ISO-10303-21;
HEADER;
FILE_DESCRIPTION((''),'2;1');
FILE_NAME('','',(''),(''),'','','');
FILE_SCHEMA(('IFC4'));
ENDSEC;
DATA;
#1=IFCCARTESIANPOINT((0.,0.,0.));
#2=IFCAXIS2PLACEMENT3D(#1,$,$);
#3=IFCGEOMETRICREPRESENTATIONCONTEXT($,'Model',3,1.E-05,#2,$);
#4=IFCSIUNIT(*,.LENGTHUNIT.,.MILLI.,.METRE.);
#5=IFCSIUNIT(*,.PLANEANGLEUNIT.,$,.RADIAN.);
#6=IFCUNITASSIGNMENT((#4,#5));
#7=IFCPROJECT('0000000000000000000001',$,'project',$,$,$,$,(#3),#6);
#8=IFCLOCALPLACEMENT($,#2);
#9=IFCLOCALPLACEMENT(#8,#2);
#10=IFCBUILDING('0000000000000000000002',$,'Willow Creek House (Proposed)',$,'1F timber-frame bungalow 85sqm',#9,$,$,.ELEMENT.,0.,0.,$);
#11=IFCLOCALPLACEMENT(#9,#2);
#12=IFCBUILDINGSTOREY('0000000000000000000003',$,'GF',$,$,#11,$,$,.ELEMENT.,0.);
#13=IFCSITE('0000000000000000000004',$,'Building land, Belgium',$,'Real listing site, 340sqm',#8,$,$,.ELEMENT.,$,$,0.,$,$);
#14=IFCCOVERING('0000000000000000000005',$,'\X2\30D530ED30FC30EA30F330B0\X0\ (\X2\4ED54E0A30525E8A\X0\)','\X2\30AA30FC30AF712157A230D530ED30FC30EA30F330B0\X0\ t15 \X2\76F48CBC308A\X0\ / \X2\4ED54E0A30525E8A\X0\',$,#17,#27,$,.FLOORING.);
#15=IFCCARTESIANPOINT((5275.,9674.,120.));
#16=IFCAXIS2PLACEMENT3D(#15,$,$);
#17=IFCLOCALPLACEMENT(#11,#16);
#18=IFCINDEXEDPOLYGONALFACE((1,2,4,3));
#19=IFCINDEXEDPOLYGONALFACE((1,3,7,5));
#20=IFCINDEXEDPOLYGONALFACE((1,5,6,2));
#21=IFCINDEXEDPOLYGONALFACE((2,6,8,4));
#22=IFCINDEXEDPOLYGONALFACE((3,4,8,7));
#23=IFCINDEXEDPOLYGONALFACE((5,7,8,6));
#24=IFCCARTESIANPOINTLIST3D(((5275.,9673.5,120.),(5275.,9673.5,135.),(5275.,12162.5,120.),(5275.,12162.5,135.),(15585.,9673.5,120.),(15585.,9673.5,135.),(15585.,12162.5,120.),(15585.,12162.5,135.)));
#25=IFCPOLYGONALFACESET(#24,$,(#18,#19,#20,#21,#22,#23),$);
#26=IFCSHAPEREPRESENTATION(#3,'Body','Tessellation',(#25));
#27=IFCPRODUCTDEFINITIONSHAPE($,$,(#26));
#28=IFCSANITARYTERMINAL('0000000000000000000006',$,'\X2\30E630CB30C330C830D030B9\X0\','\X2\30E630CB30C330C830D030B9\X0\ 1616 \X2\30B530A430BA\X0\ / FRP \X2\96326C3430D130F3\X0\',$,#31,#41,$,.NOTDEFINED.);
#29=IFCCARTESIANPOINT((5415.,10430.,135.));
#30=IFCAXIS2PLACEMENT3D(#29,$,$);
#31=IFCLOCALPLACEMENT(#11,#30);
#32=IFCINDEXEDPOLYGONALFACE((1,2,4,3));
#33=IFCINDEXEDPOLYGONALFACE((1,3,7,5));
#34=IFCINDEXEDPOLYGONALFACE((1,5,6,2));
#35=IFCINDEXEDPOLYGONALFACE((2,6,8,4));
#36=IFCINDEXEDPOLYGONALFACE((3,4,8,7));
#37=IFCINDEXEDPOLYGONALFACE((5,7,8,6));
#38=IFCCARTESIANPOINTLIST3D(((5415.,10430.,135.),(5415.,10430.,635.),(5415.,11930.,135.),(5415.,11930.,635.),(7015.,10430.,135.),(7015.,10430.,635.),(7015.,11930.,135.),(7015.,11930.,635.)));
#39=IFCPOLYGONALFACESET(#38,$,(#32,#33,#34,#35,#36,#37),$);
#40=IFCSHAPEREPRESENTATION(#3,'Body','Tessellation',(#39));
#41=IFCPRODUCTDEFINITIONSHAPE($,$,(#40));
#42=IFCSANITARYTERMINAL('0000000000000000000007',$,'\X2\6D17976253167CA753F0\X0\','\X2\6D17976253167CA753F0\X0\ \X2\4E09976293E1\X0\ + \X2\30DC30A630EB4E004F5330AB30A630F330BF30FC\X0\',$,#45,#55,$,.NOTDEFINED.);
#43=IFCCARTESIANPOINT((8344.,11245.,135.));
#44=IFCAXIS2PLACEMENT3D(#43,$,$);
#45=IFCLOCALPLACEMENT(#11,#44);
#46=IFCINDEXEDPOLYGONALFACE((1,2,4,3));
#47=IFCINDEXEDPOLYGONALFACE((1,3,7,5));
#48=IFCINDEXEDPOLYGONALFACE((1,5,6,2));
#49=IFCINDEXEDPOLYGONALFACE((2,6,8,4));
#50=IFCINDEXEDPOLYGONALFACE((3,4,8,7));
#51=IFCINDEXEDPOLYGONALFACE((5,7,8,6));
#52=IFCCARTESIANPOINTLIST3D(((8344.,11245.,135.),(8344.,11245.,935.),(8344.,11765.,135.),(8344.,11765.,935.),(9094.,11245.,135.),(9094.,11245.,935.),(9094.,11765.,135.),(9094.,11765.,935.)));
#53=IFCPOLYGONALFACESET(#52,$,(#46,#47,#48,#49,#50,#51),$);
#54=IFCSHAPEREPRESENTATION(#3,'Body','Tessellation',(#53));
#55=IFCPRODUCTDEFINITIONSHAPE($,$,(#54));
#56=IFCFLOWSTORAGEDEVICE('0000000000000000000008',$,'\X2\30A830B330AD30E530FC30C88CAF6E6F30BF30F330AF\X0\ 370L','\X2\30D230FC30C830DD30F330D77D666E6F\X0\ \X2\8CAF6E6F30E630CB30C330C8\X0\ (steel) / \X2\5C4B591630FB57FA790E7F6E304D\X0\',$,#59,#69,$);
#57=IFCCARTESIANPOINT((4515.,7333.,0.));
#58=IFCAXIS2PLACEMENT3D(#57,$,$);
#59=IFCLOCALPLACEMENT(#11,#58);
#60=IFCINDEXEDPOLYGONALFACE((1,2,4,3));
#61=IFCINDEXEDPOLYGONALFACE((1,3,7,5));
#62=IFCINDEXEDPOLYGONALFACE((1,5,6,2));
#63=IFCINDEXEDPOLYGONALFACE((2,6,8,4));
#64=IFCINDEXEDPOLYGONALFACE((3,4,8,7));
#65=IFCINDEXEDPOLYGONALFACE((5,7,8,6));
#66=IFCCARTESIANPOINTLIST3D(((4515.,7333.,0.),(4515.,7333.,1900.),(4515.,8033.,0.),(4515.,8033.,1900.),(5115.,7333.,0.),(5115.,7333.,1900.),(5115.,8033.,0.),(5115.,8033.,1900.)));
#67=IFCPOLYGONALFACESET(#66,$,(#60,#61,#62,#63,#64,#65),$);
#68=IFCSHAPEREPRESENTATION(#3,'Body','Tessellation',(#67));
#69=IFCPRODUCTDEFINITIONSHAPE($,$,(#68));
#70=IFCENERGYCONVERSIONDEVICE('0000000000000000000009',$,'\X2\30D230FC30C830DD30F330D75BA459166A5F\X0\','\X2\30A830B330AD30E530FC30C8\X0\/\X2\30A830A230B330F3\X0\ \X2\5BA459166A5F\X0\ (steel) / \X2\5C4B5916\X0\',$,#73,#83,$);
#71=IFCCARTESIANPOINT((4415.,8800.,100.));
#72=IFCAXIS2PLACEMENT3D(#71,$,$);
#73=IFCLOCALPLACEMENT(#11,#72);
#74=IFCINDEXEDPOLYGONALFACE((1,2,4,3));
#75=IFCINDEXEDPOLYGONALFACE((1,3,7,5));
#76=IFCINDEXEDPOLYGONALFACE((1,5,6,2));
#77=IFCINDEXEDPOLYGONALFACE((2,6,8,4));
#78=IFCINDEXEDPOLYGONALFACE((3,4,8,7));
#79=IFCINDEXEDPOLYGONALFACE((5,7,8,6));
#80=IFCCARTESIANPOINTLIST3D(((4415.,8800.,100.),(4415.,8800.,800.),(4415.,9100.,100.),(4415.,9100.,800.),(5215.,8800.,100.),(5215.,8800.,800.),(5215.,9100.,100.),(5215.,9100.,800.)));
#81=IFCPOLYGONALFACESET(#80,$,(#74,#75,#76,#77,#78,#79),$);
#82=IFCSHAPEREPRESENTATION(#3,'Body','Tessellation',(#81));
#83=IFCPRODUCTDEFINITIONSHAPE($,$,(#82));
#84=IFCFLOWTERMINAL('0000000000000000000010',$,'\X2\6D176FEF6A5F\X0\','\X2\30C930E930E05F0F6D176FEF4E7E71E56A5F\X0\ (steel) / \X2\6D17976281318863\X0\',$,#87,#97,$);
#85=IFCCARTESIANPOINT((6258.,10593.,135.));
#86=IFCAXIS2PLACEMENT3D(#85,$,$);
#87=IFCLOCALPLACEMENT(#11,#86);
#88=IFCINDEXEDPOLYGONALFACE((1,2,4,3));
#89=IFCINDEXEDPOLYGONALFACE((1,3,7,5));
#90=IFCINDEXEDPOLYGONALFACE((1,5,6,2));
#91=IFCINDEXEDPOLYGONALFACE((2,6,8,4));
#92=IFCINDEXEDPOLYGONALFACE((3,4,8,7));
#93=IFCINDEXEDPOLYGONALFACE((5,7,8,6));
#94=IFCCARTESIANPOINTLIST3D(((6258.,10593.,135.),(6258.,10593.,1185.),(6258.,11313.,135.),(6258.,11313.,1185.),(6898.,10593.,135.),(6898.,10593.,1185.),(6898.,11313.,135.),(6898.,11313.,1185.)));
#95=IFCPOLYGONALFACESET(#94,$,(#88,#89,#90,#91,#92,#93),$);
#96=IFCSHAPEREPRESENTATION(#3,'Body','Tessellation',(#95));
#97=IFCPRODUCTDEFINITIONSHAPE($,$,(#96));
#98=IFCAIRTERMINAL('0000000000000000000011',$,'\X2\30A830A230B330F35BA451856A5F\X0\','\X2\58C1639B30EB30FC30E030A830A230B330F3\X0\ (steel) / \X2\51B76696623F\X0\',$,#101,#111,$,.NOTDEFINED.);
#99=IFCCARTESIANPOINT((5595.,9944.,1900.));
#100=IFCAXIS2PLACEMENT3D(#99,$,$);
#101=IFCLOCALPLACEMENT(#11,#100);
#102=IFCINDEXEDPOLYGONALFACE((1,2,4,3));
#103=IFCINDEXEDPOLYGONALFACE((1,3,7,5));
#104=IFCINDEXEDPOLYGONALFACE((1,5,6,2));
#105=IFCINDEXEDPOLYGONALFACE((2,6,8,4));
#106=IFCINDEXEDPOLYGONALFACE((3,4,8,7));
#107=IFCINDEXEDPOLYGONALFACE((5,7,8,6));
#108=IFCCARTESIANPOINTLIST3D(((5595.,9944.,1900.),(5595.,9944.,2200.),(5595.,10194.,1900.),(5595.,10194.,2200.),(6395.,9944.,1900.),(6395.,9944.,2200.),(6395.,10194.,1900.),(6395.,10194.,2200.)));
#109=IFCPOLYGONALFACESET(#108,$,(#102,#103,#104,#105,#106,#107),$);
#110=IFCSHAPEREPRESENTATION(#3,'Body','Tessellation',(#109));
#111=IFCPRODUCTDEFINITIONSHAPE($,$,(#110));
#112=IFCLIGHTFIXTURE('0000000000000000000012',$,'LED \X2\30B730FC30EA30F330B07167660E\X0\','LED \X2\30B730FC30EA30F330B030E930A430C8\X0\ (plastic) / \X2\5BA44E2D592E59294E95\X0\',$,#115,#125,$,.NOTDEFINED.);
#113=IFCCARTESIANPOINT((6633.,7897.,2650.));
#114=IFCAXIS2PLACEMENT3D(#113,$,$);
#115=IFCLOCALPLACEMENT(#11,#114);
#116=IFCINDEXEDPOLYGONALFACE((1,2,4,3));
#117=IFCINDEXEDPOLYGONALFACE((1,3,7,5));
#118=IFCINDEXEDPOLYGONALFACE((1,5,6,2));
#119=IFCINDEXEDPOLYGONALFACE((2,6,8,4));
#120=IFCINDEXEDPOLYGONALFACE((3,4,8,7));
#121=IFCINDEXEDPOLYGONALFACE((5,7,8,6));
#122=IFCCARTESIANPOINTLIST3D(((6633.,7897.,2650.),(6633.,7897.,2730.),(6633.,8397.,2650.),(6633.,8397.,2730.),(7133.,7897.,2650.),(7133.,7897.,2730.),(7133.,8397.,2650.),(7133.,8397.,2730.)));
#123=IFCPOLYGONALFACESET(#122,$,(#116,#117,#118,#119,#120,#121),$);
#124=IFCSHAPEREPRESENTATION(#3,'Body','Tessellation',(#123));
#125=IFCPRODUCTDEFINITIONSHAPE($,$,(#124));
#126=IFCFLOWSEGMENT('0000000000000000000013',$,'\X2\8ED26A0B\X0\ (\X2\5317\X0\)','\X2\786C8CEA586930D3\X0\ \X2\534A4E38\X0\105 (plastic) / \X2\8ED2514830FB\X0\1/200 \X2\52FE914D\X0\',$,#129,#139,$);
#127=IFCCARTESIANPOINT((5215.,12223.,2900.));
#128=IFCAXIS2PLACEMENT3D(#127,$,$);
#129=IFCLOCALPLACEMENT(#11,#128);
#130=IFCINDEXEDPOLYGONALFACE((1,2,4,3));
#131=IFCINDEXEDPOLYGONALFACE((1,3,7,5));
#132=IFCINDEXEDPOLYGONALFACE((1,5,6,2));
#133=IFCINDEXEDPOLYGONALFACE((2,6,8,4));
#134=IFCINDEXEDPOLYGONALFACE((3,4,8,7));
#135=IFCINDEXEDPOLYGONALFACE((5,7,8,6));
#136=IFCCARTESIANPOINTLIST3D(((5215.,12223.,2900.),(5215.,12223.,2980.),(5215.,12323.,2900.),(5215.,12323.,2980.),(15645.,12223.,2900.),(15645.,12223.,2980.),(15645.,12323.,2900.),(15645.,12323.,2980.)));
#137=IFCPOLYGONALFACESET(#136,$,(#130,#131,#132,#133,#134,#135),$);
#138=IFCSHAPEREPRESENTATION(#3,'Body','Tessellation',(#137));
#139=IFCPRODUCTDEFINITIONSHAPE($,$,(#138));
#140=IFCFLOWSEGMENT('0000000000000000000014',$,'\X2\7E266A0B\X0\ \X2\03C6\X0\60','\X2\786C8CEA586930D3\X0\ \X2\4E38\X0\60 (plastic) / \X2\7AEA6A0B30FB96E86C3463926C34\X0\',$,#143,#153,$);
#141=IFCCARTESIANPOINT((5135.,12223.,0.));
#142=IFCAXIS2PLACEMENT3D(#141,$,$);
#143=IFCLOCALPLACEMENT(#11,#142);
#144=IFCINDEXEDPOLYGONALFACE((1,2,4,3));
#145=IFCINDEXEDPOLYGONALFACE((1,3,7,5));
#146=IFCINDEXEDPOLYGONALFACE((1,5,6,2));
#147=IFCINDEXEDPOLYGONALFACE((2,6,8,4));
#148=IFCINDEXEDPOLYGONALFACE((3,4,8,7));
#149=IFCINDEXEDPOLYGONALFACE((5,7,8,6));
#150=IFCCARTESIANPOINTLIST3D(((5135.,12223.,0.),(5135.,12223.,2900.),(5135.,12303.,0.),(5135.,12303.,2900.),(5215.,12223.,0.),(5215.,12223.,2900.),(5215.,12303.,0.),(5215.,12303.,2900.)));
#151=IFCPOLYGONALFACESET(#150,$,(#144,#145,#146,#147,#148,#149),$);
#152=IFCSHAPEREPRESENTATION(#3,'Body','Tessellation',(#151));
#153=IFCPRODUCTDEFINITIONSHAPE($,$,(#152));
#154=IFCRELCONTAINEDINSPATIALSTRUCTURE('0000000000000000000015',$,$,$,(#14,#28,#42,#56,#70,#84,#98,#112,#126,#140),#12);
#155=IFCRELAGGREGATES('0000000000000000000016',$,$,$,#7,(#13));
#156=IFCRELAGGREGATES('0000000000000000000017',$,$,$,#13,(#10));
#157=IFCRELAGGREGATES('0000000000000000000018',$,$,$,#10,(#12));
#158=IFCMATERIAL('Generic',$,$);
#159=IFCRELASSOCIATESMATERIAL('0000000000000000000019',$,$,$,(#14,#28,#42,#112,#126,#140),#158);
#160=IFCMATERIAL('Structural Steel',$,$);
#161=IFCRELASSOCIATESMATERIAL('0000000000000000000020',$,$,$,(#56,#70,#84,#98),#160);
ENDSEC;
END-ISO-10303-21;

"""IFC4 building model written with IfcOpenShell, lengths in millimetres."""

from ifc_helpers import new_model, si_unit, frame, frame_2d, origin, place, context, project, spatial, rectangle, extrude, material, element, save


model = new_model("IFC4")

# Units and contexts
model_context = context("Model", 3, precision=1e-05, world=origin())
ifc_project = project(units=[si_unit("LENGTHUNIT", "METRE", prefix="MILLI"), si_unit("PLANEANGLEUNIT", "RADIAN")], contexts=[model_context])

# Site, building, storey
site_placement = place(None, origin())
site = spatial("IfcSite", under=ifc_project, at=site_placement, Name="Building land, Belgium", ObjectType="Real listing site, 340sqm", CompositionType="ELEMENT", RefElevation=0.0)
building_placement = place(site_placement, origin())
building = spatial("IfcBuilding", under=site, at=building_placement, Name="Willow Creek House (Proposed)", ObjectType="1F timber-frame bungalow 85sqm", CompositionType="ELEMENT", ElevationOfRefHeight=0.0, ElevationOfTerrain=0.0)
storey_placement = place(building_placement, origin())
storey = spatial("IfcBuildingStorey", under=building, at=storey_placement, Name="GF", CompositionType="ELEMENT", Elevation=0.0)

# Shared definitions
ifc_material_1 = material(Name="Structural Steel")

# Covering
ifc_material_2 = material(Name="Generic")
covering_1_placement = place(storey_placement, frame((5275.0, 9674.0, 120.0)))
element("IfcCovering", 1, at=covering_1_placement, inside=storey, material=ifc_material_2, Name="フローリング (仕上げ床)", Description="オーク無垢フローリング t15 直貼り / 仕上げ床", PredefinedType="FLOORING", context=model_context, shape_type="SweptSolid", body=[
    extrude(rectangle(XDim=10310.0, YDim=2489.0, at=frame_2d((5155.0, 1244.0))), frame((5275.0, 9674.0, 120.0)), (0.0, 0.0, 1.0), 15.0),
])

# Sanitary terminals
sanitary_terminal_1_placement = place(storey_placement, frame((5415.0, 10430.0, 135.0)))
element("IfcSanitaryTerminal", 2, at=sanitary_terminal_1_placement, inside=storey, material=ifc_material_2, Name="ユニットバス", Description="ユニットバス 1616 サイズ / FRP 防水パン", PredefinedType="NOTDEFINED", context=model_context, shape_type="SweptSolid", body=[
    extrude(rectangle(XDim=1600.0, YDim=1500.0, at=frame_2d((800.0, 750.0))), frame((5415.0, 10430.0, 135.0)), (0.0, 0.0, 1.0), 500.0),
])
sanitary_terminal_2_placement = place(storey_placement, frame((8344.0, 11245.0, 135.0)))
element("IfcSanitaryTerminal", 3, at=sanitary_terminal_2_placement, inside=storey, material=ifc_material_2, Name="洗面化粧台", Description="洗面化粧台 三面鏡 + ボウル一体カウンター", PredefinedType="NOTDEFINED", context=model_context, shape_type="SweptSolid", body=[
    extrude(rectangle(XDim=750.0, YDim=520.0, at=frame_2d((375.0, 260.0))), frame((8344.0, 11245.0, 135.0)), (0.0, 0.0, 1.0), 800.0),
])

# Flow storage device
flow_storage_device_placement = place(storey_placement, frame((4515.0, 7333.0, 0.0)))
element("IfcFlowStorageDevice", 4, at=flow_storage_device_placement, inside=storey, material=ifc_material_1, Name="エコキュート貯湯タンク 370L", Description="ヒートポンプ給湯 貯湯ユニット (steel) / 屋外・基礎置き", context=model_context, shape_type="SweptSolid", body=[
    extrude(rectangle(XDim=600.0, YDim=700.0, at=frame_2d((300.0, 350.0))), frame((4515.0, 7333.0, 0.0)), (0.0, 0.0, 1.0), 1900.0),
])

# Energy conversion device
energy_conversion_device_placement = place(storey_placement, frame((4415.0, 8800.0, 100.0)))
element("IfcEnergyConversionDevice", 5, at=energy_conversion_device_placement, inside=storey, material=ifc_material_1, Name="ヒートポンプ室外機", Description="エコキュート/エアコン 室外機 (steel) / 屋外", context=model_context, shape_type="SweptSolid", body=[
    extrude(rectangle(XDim=800.0, YDim=300.0, at=frame_2d((400.0, 150.0))), frame((4415.0, 8800.0, 100.0)), (0.0, 0.0, 1.0), 700.0),
])

# Flow terminal
flow_terminal_placement = place(storey_placement, frame((6258.0, 10593.0, 135.0)))
element("IfcFlowTerminal", 6, at=flow_terminal_placement, inside=storey, material=ifc_material_1, Name="洗濯機", Description="ドラム式洗濯乾燥機 (steel) / 洗面脱衣", context=model_context, shape_type="SweptSolid", body=[
    extrude(rectangle(XDim=640.0, YDim=720.0, at=frame_2d((320.0, 360.0))), frame((6258.0, 10593.0, 135.0)), (0.0, 0.0, 1.0), 1050.0),
])

# Air terminal
air_terminal_placement = place(storey_placement, frame((5595.0, 9944.0, 1900.0)))
element("IfcAirTerminal", 7, at=air_terminal_placement, inside=storey, material=ifc_material_1, Name="エアコン室内機", Description="壁掛ルームエアコン (steel) / 冷暖房", PredefinedType="NOTDEFINED", context=model_context, shape_type="SweptSolid", body=[
    extrude(rectangle(XDim=800.0, YDim=250.0, at=frame_2d((400.0, 125.0))), frame((5595.0, 9944.0, 1900.0)), (0.0, 0.0, 1.0), 300.0),
])

# Light fixture
light_fixture_placement = place(storey_placement, frame((6633.0, 7897.0, 2650.0)))
element("IfcLightFixture", 8, at=light_fixture_placement, inside=storey, material=ifc_material_2, Name="LED シーリング照明", Description="LED シーリングライト (plastic) / 室中央天井", PredefinedType="NOTDEFINED", context=model_context, shape_type="SweptSolid", body=[
    extrude(rectangle(XDim=500.0, YDim=500.0, at=frame_2d((250.0, 250.0))), frame((6633.0, 7897.0, 2650.0)), (0.0, 0.0, 1.0), 80.0),
])

# Flow segments
flow_segment_1_placement = place(storey_placement, frame((5215.0, 12223.0, 2900.0)))
element("IfcFlowSegment", 9, at=flow_segment_1_placement, inside=storey, material=ifc_material_2, Name="軒樋 (北)", Description="硬質塩ビ 半丸105 (plastic) / 軒先・1/200 勾配", context=model_context, shape_type="SweptSolid", body=[
    extrude(rectangle(XDim=10430.0, YDim=100.0, at=frame_2d((5215.0, 50.0))), frame((5215.0, 12223.0, 2900.0)), (0.0, 0.0, 1.0), 80.0),
])
flow_segment_2_placement = place(storey_placement, frame((5135.0, 12223.0, 0.0)))
element("IfcFlowSegment", 10, at=flow_segment_2_placement, inside=storey, material=ifc_material_2, Name="縦樋 φ60", Description="硬質塩ビ 丸60 (plastic) / 竪樋・雨水排水", context=model_context, shape_type="SweptSolid", body=[
    extrude(rectangle(XDim=80.0, YDim=80.0, at=frame_2d((40.0, 40.0))), frame((5135.0, 12223.0, 0.0)), (0.0, 0.0, 1.0), 2900.0),
])

save(model, "model.ifc")
